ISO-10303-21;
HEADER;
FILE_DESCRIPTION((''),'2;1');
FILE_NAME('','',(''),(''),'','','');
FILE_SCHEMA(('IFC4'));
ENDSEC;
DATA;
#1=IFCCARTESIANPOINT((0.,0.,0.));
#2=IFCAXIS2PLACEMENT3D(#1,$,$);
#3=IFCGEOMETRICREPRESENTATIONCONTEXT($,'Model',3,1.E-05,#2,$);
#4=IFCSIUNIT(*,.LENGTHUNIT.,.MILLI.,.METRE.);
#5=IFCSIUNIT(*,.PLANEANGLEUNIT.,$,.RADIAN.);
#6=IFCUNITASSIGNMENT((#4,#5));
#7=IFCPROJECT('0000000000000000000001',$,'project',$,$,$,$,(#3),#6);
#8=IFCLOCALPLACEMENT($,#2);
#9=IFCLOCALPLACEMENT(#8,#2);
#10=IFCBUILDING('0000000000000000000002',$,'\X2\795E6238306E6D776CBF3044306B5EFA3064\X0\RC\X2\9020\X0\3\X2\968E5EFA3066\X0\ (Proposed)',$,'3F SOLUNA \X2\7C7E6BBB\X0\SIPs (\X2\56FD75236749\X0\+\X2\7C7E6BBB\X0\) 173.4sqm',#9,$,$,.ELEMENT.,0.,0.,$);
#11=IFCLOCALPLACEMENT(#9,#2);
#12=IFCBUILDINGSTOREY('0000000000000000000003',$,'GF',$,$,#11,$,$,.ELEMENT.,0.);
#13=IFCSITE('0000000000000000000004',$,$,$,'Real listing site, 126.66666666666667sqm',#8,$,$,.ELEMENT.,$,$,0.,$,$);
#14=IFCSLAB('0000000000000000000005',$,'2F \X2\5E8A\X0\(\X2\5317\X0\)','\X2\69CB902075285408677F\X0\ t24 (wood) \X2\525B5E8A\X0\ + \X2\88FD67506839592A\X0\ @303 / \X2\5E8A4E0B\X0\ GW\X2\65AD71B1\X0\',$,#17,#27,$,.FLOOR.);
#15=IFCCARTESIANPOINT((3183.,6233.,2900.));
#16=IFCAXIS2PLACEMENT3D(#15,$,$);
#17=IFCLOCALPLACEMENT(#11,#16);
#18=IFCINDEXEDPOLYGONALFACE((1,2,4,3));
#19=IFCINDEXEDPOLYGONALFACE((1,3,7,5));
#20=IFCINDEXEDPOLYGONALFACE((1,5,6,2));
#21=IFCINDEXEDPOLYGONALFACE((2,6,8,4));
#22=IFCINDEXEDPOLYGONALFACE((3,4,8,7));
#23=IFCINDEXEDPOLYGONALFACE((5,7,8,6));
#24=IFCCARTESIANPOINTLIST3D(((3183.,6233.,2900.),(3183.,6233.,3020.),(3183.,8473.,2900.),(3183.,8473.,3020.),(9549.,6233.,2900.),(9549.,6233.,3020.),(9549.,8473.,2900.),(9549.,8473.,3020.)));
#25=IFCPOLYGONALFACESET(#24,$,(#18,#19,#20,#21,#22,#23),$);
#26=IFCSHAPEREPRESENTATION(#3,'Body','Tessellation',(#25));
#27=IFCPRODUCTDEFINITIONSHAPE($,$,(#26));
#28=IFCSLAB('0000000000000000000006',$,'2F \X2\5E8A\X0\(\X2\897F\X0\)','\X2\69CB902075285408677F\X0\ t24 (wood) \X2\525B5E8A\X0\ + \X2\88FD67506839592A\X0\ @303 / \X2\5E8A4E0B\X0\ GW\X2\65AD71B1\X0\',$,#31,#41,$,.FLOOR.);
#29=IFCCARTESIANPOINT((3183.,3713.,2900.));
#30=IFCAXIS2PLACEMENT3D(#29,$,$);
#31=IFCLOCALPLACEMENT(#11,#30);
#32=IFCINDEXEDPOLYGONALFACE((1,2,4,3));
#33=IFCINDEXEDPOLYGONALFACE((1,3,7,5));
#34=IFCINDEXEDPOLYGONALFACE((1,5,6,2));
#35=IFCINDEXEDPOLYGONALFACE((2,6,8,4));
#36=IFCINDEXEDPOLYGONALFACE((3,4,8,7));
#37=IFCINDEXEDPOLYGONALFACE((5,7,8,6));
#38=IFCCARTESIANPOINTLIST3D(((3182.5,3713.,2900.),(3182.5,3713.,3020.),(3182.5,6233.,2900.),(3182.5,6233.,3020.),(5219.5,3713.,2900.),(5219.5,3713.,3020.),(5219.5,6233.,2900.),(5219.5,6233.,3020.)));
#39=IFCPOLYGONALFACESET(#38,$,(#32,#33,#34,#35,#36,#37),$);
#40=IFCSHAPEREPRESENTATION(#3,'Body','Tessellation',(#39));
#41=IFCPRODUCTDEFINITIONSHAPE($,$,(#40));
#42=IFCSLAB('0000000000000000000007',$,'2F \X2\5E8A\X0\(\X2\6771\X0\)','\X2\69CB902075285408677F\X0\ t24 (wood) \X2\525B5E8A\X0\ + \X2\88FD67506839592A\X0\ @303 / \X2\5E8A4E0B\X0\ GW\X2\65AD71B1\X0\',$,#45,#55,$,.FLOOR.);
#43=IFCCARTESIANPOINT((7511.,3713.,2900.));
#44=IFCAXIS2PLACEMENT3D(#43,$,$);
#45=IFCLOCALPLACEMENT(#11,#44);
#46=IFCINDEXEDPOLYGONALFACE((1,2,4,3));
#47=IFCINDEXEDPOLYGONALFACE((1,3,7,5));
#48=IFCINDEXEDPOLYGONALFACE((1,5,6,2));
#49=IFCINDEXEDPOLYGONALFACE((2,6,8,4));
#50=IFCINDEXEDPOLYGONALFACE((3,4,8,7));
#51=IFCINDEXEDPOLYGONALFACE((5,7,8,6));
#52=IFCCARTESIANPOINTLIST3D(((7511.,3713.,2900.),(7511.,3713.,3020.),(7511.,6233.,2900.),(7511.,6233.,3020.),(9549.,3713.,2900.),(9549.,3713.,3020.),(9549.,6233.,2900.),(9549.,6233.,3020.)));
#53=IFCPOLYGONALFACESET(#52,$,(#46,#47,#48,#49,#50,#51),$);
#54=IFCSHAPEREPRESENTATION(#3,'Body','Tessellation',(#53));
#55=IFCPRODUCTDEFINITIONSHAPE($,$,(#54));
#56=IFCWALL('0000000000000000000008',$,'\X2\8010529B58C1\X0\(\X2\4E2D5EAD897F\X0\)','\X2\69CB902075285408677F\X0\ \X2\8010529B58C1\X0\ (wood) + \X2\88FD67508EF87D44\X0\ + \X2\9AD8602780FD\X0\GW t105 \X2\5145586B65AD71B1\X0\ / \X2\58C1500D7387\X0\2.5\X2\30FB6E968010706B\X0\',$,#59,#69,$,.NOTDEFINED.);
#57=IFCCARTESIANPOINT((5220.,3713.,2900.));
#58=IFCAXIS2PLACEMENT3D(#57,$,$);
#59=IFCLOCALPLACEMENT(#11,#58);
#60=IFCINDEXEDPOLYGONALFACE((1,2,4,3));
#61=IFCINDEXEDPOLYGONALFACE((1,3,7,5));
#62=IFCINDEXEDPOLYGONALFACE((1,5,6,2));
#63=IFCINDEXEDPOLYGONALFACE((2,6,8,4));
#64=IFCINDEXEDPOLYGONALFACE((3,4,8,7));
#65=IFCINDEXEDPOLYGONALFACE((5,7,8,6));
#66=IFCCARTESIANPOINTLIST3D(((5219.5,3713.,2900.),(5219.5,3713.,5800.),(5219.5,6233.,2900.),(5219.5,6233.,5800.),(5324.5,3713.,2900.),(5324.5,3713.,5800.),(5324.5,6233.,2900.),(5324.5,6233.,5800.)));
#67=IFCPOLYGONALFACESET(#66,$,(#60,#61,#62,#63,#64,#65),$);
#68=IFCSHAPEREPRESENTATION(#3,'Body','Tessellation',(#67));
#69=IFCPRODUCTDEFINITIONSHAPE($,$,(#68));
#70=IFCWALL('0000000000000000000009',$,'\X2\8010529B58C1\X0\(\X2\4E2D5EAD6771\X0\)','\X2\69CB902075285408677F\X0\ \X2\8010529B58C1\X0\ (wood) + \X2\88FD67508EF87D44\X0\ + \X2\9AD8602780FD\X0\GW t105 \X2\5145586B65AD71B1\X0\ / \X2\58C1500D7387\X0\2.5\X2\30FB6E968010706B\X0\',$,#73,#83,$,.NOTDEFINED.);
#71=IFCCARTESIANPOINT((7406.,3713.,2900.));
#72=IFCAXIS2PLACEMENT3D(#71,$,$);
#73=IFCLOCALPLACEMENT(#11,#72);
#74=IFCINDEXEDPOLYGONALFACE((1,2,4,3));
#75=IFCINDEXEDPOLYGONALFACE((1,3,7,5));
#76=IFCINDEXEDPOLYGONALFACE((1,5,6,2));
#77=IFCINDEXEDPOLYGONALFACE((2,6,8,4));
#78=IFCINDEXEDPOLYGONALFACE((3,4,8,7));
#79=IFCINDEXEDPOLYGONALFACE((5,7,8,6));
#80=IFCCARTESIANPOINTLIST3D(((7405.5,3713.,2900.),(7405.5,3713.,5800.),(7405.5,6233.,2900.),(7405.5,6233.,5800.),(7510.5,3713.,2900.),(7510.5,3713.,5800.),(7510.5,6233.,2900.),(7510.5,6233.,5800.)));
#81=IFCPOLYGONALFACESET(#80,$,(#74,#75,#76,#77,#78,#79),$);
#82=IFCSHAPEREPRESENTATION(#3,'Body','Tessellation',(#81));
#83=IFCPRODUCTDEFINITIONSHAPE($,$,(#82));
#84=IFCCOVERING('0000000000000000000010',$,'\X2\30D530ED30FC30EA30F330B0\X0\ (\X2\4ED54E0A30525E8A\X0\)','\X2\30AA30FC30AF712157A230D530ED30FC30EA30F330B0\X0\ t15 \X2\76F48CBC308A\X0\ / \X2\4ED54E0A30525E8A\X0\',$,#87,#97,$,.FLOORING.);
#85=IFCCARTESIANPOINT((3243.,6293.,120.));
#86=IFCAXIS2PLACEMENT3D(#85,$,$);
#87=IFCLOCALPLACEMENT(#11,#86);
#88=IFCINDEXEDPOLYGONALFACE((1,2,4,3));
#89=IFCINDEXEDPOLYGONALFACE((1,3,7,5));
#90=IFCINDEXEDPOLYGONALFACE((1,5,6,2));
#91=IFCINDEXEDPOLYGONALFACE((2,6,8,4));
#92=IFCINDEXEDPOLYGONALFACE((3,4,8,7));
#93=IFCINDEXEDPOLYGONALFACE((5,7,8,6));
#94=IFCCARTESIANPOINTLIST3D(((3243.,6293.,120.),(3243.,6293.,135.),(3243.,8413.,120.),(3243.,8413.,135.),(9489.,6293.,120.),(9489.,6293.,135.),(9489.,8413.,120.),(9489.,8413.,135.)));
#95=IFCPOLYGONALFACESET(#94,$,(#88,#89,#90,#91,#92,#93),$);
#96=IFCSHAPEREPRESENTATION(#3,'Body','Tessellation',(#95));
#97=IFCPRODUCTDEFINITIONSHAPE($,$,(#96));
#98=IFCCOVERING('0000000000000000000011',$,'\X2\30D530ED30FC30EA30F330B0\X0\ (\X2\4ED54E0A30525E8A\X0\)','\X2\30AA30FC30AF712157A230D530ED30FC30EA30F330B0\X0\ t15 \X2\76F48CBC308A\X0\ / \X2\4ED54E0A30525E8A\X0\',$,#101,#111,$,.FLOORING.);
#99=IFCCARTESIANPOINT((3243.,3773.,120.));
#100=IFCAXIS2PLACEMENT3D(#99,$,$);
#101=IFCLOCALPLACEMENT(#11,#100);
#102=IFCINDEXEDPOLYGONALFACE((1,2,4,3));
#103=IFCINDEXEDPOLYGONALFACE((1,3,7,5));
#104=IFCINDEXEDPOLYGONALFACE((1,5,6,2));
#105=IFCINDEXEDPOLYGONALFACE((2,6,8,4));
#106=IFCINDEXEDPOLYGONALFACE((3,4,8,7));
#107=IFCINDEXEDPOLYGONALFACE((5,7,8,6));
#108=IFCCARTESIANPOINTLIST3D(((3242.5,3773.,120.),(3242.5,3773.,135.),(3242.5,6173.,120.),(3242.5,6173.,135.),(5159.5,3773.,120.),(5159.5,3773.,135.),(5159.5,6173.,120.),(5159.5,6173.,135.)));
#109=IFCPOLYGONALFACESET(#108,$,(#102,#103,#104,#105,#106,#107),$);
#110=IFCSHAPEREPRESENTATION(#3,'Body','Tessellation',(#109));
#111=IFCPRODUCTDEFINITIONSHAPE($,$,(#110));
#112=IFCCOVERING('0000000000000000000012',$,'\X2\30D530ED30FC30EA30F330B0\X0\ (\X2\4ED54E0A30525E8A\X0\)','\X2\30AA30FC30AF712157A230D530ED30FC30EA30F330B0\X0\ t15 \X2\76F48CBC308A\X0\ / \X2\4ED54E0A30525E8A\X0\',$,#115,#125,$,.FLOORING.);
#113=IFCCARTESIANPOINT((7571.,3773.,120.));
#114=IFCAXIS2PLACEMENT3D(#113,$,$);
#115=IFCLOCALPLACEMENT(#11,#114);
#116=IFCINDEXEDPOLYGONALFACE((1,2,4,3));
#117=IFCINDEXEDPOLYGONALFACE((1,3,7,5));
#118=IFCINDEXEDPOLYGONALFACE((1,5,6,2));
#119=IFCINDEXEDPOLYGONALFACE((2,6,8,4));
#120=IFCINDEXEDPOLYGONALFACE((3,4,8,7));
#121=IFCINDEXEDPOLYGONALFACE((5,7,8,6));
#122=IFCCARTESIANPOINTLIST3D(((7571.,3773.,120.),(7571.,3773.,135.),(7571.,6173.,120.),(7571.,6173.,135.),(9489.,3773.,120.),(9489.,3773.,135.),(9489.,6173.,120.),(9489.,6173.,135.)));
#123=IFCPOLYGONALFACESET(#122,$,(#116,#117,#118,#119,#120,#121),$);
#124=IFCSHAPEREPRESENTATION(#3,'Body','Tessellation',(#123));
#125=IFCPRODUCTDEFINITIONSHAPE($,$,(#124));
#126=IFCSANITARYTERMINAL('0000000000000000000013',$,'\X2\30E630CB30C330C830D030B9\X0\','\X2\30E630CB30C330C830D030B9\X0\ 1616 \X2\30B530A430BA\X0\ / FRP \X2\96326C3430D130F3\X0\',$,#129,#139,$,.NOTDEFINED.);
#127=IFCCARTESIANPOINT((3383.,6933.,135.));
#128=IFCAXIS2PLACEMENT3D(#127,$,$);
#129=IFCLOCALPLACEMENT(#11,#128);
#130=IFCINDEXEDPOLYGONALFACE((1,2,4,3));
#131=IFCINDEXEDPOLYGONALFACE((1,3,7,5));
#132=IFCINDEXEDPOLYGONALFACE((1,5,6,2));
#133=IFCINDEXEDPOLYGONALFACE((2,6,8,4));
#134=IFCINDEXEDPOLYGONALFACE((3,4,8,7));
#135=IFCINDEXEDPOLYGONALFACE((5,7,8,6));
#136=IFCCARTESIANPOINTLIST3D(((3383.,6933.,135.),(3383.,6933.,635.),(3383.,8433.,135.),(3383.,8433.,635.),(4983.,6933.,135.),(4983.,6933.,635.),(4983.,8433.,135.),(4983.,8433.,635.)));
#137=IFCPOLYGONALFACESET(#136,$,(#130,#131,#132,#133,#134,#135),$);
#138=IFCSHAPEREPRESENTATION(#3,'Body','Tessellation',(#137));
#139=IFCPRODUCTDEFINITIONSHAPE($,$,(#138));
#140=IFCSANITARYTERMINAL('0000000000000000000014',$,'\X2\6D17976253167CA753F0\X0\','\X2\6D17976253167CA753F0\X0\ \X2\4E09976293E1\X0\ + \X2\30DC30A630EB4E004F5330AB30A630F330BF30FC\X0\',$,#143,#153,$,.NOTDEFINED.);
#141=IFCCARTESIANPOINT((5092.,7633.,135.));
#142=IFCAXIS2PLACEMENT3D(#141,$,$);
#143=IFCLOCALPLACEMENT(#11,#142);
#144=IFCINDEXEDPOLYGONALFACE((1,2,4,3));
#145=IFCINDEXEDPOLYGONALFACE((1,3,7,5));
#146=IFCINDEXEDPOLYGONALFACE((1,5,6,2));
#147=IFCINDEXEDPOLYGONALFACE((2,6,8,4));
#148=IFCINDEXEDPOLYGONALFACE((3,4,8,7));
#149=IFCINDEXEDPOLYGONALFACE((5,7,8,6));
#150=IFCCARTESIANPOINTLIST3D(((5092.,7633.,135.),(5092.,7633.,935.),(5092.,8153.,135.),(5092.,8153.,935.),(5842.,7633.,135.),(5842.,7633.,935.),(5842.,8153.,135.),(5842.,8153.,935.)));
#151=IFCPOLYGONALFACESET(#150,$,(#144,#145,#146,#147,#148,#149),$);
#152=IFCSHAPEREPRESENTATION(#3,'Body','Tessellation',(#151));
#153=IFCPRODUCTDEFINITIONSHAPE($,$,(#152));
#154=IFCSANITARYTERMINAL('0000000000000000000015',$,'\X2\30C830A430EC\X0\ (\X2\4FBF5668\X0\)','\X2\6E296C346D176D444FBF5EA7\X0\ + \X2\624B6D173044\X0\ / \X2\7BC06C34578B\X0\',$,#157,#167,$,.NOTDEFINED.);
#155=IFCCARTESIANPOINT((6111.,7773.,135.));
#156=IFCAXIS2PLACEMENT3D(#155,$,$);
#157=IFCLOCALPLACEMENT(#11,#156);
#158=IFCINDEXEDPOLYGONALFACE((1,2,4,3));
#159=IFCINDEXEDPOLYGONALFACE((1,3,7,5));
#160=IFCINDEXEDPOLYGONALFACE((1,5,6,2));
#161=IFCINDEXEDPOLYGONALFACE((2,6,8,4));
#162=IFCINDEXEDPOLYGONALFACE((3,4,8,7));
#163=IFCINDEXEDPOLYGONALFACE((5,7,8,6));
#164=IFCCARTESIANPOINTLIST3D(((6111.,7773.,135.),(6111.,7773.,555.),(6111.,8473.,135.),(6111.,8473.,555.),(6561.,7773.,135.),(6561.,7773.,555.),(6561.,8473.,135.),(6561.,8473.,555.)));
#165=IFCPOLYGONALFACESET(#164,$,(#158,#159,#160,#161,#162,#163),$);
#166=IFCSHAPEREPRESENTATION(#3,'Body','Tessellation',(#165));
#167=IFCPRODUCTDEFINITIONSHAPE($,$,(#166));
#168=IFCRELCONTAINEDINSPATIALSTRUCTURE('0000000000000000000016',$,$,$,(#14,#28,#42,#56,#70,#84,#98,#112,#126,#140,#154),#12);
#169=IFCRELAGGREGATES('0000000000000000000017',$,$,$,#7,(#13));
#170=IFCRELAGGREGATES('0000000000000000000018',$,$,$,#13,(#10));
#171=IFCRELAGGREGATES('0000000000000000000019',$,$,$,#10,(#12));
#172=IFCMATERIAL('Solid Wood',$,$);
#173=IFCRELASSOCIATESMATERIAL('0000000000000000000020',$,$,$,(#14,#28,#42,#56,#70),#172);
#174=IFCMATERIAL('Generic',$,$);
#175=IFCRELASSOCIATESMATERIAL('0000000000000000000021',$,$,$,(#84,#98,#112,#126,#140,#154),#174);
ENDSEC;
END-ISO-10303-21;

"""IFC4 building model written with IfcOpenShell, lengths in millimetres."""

from ifc_helpers import new_model, si_unit, frame, frame_2d, origin, place, context, project, spatial, rectangle, extrude, material, element, save


model = new_model("IFC4")

# Units and contexts
model_context = context("Model", 3, precision=1e-05, world=origin())
ifc_project = project(units=[si_unit("LENGTHUNIT", "METRE", prefix="MILLI"), si_unit("PLANEANGLEUNIT", "RADIAN")], contexts=[model_context])

# Site, building, storey
site_placement = place(None, origin())
site = spatial("IfcSite", under=ifc_project, at=site_placement, ObjectType="Real listing site, 126.66666666666667sqm", CompositionType="ELEMENT", RefElevation=0.0)
building_placement = place(site_placement, origin())
building = spatial("IfcBuilding", under=site, at=building_placement, Name="神戸の海沿いに建つRC造3階建て (Proposed)", ObjectType="3F SOLUNA 籾殻SIPs (国産杉+籾殻) 173.4sqm", CompositionType="ELEMENT", ElevationOfRefHeight=0.0, ElevationOfTerrain=0.0)
storey_placement = place(building_placement, origin())
storey = spatial("IfcBuildingStorey", under=building, at=storey_placement, Name="GF", CompositionType="ELEMENT", Elevation=0.0)

# Slabs
ifc_material_1 = material(Name="Solid Wood")
slab_1_placement = place(storey_placement, frame((3183.0, 6233.0, 2900.0)))
element("IfcSlab", 1, at=slab_1_placement, inside=storey, material=ifc_material_1, Name="2F 床(北)", Description="構造用合板 t24 (wood) 剛床 + 製材根太 @303 / 床下 GW断熱", PredefinedType="FLOOR", context=model_context, shape_type="SweptSolid", body=[
    extrude(rectangle(XDim=6366.0, YDim=2240.0, at=frame_2d((3183.0, 1120.0))), frame((3183.0, 6233.0, 2900.0)), (0.0, 0.0, 1.0), 120.0),
])
slab_2_placement = place(storey_placement, frame((3183.0, 3713.0, 2900.0)))
element("IfcSlab", 2, at=slab_2_placement, inside=storey, material=ifc_material_1, Name="2F 床(西)", Description="構造用合板 t24 (wood) 剛床 + 製材根太 @303 / 床下 GW断熱", PredefinedType="FLOOR", context=model_context, shape_type="SweptSolid", body=[
    extrude(rectangle(XDim=2037.0, YDim=2520.0, at=frame_2d((1018.0, 1260.0))), frame((3183.0, 3713.0, 2900.0)), (0.0, 0.0, 1.0), 120.0),
])
slab_3_placement = place(storey_placement, frame((7511.0, 3713.0, 2900.0)))
element("IfcSlab", 3, at=slab_3_placement, inside=storey, material=ifc_material_1, Name="2F 床(東)", Description="構造用合板 t24 (wood) 剛床 + 製材根太 @303 / 床下 GW断熱", PredefinedType="FLOOR", context=model_context, shape_type="SweptSolid", body=[
    extrude(rectangle(XDim=2038.0, YDim=2520.0, at=frame_2d((1019.0, 1260.0))), frame((7511.0, 3713.0, 2900.0)), (0.0, 0.0, 1.0), 120.0),
])

# Walls
wall_1_placement = place(storey_placement, frame((5220.0, 3713.0, 2900.0)))
element("IfcWall", 4, at=wall_1_placement, inside=storey, material=ifc_material_1, Name="耐力壁(中庭西)", Description="構造用合板 耐力壁 (wood) + 製材軸組 + 高性能GW t105 充填断熱 / 壁倍率2.5・準耐火", PredefinedType="NOTDEFINED", context=model_context, shape_type="SweptSolid", body=[
    extrude(rectangle(XDim=105.0, YDim=2520.0, at=frame_2d((52.0, 1260.0))), frame((5220.0, 3713.0, 2900.0)), (0.0, 0.0, 1.0), 2900.0),
])
wall_2_placement = place(storey_placement, frame((7406.0, 3713.0, 2900.0)))
element("IfcWall", 5, at=wall_2_placement, inside=storey, material=ifc_material_1, Name="耐力壁(中庭東)", Description="構造用合板 耐力壁 (wood) + 製材軸組 + 高性能GW t105 充填断熱 / 壁倍率2.5・準耐火", PredefinedType="NOTDEFINED", context=model_context, shape_type="SweptSolid", body=[
    extrude(rectangle(XDim=105.0, YDim=2520.0, at=frame_2d((52.0, 1260.0))), frame((7406.0, 3713.0, 2900.0)), (0.0, 0.0, 1.0), 2900.0),
])

# Coverings
ifc_material_2 = material(Name="Generic")
covering_1_placement = place(storey_placement, frame((3243.0, 6293.0, 120.0)))
element("IfcCovering", 6, at=covering_1_placement, inside=storey, material=ifc_material_2, Name="フローリング (仕上げ床)", Description="オーク無垢フローリング t15 直貼り / 仕上げ床", PredefinedType="FLOORING", context=model_context, shape_type="SweptSolid", body=[
    extrude(rectangle(XDim=6246.0, YDim=2120.0, at=frame_2d((3123.0, 1060.0))), frame((3243.0, 6293.0, 120.0)), (0.0, 0.0, 1.0), 15.0),
])
covering_2_placement = place(storey_placement, frame((3243.0, 3773.0, 120.0)))
element("IfcCovering", 7, at=covering_2_placement, inside=storey, material=ifc_material_2, Name="フローリング (仕上げ床)", Description="オーク無垢フローリング t15 直貼り / 仕上げ床", PredefinedType="FLOORING", context=model_context, shape_type="SweptSolid", body=[
    extrude(rectangle(XDim=1917.0, YDim=2400.0, at=frame_2d((958.0, 1200.0))), frame((3243.0, 3773.0, 120.0)), (0.0, 0.0, 1.0), 15.0),
])
covering_3_placement = place(storey_placement, frame((7571.0, 3773.0, 120.0)))
element("IfcCovering", 8, at=covering_3_placement, inside=storey, material=ifc_material_2, Name="フローリング (仕上げ床)", Description="オーク無垢フローリング t15 直貼り / 仕上げ床", PredefinedType="FLOORING", context=model_context, shape_type="SweptSolid", body=[
    extrude(rectangle(XDim=1918.0, YDim=2400.0, at=frame_2d((959.0, 1200.0))), frame((7571.0, 3773.0, 120.0)), (0.0, 0.0, 1.0), 15.0),
])

# Sanitary terminals
sanitary_terminal_1_placement = place(storey_placement, frame((3383.0, 6933.0, 135.0)))
element("IfcSanitaryTerminal", 9, at=sanitary_terminal_1_placement, inside=storey, material=ifc_material_2, Name="ユニットバス", Description="ユニットバス 1616 サイズ / FRP 防水パン", PredefinedType="NOTDEFINED", context=model_context, shape_type="SweptSolid", body=[
    extrude(rectangle(XDim=1600.0, YDim=1500.0, at=frame_2d((800.0, 750.0))), frame((3383.0, 6933.0, 135.0)), (0.0, 0.0, 1.0), 500.0),
])
sanitary_terminal_2_placement = place(storey_placement, frame((5092.0, 7633.0, 135.0)))
element("IfcSanitaryTerminal", 10, at=sanitary_terminal_2_placement, inside=storey, material=ifc_material_2, Name="洗面化粧台", Description="洗面化粧台 三面鏡 + ボウル一体カウンター", PredefinedType="NOTDEFINED", context=model_context, shape_type="SweptSolid", body=[
    extrude(rectangle(XDim=750.0, YDim=520.0, at=frame_2d((375.0, 260.0))), frame((5092.0, 7633.0, 135.0)), (0.0, 0.0, 1.0), 800.0),
])
sanitary_terminal_3_placement = place(storey_placement, frame((6111.0, 7773.0, 135.0)))
element("IfcSanitaryTerminal", 11, at=sanitary_terminal_3_placement, inside=storey, material=ifc_material_2, Name="トイレ (便器)", Description="温水洗浄便座 + 手洗い / 節水型", PredefinedType="NOTDEFINED", context=model_context, shape_type="SweptSolid", body=[
    extrude(rectangle(XDim=450.0, YDim=700.0, at=frame_2d((225.0, 350.0))), frame((6111.0, 7773.0, 135.0)), (0.0, 0.0, 1.0), 420.0),
])

save(model, "model.ifc")
